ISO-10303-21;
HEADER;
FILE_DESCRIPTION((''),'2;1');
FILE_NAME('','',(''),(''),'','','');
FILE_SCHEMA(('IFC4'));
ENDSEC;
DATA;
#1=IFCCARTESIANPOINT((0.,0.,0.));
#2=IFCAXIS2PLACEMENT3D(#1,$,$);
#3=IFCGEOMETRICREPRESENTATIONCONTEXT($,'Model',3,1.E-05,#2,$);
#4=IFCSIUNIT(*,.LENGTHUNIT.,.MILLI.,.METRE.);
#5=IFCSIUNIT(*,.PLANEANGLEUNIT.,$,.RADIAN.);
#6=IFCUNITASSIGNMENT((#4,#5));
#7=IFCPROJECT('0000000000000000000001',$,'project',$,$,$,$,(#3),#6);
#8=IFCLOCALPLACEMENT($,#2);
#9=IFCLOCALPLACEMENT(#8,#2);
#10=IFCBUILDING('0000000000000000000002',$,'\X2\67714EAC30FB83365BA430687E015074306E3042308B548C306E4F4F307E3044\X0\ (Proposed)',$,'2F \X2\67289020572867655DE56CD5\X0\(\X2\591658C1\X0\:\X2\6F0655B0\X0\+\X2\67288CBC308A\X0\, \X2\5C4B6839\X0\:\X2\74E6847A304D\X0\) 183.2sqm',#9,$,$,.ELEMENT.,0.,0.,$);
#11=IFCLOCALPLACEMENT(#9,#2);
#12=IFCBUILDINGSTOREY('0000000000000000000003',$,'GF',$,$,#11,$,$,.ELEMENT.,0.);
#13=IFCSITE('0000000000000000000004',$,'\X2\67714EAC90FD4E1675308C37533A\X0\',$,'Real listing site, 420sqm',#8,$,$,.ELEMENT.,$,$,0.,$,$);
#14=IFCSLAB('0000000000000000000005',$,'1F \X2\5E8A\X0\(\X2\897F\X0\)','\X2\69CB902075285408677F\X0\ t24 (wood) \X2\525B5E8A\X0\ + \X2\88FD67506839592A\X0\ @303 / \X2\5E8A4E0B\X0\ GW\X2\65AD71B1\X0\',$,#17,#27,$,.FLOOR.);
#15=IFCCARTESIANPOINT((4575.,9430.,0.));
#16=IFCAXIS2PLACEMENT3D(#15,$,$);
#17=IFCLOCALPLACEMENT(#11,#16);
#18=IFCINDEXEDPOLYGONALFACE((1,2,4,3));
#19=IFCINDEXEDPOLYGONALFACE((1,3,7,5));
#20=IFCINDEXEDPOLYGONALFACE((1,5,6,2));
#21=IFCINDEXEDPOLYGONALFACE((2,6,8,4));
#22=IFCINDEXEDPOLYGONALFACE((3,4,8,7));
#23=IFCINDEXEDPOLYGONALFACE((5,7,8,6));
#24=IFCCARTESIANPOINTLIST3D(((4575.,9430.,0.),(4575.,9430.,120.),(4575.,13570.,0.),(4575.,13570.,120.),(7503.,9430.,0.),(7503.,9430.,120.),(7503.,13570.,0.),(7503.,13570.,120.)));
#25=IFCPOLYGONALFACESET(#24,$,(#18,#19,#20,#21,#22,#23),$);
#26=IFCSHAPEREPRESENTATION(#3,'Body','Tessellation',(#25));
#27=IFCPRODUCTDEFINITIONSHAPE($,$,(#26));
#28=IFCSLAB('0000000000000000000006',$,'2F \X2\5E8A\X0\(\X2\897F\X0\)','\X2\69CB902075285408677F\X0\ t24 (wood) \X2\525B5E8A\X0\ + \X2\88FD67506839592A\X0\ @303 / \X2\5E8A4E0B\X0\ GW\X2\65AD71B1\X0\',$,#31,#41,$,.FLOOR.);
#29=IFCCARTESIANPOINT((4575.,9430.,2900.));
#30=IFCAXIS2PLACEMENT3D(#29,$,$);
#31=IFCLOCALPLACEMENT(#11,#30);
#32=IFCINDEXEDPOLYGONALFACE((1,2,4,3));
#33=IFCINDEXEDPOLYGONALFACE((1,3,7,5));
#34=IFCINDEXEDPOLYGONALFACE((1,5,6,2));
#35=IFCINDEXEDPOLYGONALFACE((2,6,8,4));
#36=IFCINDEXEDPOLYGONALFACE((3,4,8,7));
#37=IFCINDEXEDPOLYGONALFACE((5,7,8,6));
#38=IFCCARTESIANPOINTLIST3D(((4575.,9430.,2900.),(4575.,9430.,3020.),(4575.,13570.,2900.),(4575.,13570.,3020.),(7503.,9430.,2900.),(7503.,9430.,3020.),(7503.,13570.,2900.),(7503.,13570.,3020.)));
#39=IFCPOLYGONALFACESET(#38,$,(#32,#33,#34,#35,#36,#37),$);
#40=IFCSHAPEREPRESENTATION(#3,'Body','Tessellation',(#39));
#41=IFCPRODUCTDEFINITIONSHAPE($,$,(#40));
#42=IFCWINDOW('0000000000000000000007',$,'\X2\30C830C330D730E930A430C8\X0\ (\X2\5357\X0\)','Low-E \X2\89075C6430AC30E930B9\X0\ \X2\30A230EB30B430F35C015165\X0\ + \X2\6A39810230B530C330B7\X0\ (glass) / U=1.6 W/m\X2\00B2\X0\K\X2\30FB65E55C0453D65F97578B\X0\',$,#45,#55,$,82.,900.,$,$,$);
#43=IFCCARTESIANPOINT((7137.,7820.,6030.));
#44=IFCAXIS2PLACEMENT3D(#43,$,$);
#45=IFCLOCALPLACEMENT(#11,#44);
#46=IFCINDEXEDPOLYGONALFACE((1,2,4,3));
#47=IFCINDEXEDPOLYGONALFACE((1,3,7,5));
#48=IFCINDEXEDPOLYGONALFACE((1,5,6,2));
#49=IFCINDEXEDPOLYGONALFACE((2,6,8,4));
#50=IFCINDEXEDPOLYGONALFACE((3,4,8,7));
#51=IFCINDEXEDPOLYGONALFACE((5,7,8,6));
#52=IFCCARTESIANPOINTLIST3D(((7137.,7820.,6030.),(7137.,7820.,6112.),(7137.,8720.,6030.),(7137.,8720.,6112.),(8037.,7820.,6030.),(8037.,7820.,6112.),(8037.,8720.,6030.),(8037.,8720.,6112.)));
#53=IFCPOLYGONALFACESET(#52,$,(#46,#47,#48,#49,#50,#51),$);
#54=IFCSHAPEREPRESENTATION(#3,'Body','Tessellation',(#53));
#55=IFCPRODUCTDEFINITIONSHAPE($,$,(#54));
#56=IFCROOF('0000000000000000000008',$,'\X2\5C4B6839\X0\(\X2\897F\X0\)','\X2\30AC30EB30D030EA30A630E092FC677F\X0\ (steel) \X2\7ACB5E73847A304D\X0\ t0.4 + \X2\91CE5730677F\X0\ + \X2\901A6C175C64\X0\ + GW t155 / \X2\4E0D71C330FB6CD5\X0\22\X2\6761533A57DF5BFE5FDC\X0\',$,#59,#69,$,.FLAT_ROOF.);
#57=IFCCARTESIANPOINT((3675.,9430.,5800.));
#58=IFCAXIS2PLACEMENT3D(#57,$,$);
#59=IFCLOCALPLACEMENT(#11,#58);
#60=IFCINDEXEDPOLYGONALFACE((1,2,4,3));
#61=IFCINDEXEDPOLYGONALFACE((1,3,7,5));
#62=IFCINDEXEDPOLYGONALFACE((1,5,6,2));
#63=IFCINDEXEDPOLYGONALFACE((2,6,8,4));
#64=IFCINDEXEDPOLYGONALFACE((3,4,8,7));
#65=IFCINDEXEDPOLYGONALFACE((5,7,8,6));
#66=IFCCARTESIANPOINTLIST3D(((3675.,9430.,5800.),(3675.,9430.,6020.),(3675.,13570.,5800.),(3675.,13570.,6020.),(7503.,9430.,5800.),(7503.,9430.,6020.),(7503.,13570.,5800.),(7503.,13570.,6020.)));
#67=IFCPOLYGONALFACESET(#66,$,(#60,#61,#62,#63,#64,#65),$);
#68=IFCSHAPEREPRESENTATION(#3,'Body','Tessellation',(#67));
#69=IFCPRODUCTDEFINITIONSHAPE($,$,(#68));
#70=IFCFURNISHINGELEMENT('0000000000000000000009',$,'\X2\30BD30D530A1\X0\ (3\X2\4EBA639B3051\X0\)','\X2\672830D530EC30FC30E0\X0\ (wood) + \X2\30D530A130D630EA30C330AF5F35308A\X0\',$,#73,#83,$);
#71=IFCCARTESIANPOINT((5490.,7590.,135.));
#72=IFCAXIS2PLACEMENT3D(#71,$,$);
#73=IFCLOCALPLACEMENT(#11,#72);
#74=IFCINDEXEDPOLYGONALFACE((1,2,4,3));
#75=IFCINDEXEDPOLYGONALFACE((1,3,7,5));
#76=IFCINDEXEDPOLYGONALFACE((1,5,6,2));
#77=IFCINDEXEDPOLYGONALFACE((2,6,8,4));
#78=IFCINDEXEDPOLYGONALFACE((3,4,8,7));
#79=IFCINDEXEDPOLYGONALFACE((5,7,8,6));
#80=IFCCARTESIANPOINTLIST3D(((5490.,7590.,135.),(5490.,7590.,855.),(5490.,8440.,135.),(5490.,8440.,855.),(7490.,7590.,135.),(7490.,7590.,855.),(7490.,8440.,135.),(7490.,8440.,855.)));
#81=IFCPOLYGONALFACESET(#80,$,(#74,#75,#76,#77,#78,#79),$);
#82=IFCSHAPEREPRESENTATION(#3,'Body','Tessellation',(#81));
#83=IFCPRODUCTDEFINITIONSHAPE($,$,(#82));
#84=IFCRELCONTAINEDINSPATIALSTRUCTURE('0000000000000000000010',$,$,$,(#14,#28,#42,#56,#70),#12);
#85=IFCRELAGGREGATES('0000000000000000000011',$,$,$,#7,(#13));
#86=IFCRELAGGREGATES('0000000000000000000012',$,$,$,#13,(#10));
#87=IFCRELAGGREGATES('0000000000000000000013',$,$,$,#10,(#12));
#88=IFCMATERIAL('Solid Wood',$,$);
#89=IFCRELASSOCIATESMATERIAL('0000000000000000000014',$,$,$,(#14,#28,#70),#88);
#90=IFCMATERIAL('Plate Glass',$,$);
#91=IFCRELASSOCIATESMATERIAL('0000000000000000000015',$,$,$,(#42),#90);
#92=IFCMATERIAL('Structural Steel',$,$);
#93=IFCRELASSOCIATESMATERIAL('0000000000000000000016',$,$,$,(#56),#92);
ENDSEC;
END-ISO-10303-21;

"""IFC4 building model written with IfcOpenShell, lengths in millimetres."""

from ifc_helpers import new_model, si_unit, frame, frame_2d, origin, place, context, project, spatial, rectangle, extrude, material, element, save


model = new_model("IFC4")

# Units and contexts
model_context = context("Model", 3, precision=1e-05, world=origin())
ifc_project = project(units=[si_unit("LENGTHUNIT", "METRE", prefix="MILLI"), si_unit("PLANEANGLEUNIT", "RADIAN")], contexts=[model_context])

# Site, building, storey
site_placement = place(None, origin())
site = spatial("IfcSite", under=ifc_project, at=site_placement, Name="東京都世田谷区", ObjectType="Real listing site, 420sqm", CompositionType="ELEMENT", RefElevation=0.0)
building_placement = place(site_placement, origin())
building = spatial("IfcBuilding", under=site, at=building_placement, Name="東京・茶室と縁側のある和の住まい (Proposed)", ObjectType="2F 木造在来工法(外壁:漆喰+木貼り, 屋根:瓦葺き) 183.2sqm", CompositionType="ELEMENT", ElevationOfRefHeight=0.0, ElevationOfTerrain=0.0)
storey_placement = place(building_placement, origin())
storey = spatial("IfcBuildingStorey", under=building, at=storey_placement, Name="GF", CompositionType="ELEMENT", Elevation=0.0)

# Shared definitions
ifc_material_1 = material(Name="Solid Wood")

# Slabs
slab_1_placement = place(storey_placement, frame((4575.0, 9430.0, 0.0)))
element("IfcSlab", 1, at=slab_1_placement, inside=storey, material=ifc_material_1, Name="1F 床(西)", Description="構造用合板 t24 (wood) 剛床 + 製材根太 @303 / 床下 GW断熱", PredefinedType="FLOOR", context=model_context, shape_type="SweptSolid", body=[
    extrude(rectangle(XDim=2928.0, YDim=4140.0, at=frame_2d((1464.0, 2070.0))), frame((4575.0, 9430.0, 0.0)), (0.0, 0.0, 1.0), 120.0),
])
slab_2_placement = place(storey_placement, frame((4575.0, 9430.0, 2900.0)))
element("IfcSlab", 2, at=slab_2_placement, inside=storey, material=ifc_material_1, Name="2F 床(西)", Description="構造用合板 t24 (wood) 剛床 + 製材根太 @303 / 床下 GW断熱", PredefinedType="FLOOR", context=model_context, shape_type="SweptSolid", body=[
    extrude(rectangle(XDim=2928.0, YDim=4140.0, at=frame_2d((1464.0, 2070.0))), frame((4575.0, 9430.0, 2900.0)), (0.0, 0.0, 1.0), 120.0),
])

# Window
ifc_material_2 = material(Name="Plate Glass")
window_placement = place(storey_placement, frame((7137.0, 7820.0, 6030.0)))
element("IfcWindow", 3, at=window_placement, inside=storey, material=ifc_material_2, Name="トップライト (南)", Description="Low-E 複層ガラス アルゴン封入 + 樹脂サッシ (glass) / U=1.6 W/m²K・日射取得型", OverallHeight=82.0, OverallWidth=900.0, context=model_context, shape_type="SweptSolid", body=[
    extrude(rectangle(XDim=900.0, YDim=900.0, at=frame_2d((450.0, 450.0))), frame((7137.0, 7820.0, 6030.0)), (0.0, 0.0, 1.0), 82.0),
])

# Roof
ifc_material_3 = material(Name="Structural Steel")
for number, where, name in (
    (4, (3675.0, 9430.0, 5800.0), "屋根(西)"),
):
    element("IfcRoof", number, at=place(storey_placement, frame(where)), inside=storey, material=ifc_material_3, Name=name, Description="ガルバリウム鋼板 (steel) 立平葺き t0.4 + 野地板 + 通気層 + GW t155 / 不燃・法22条区域対応", PredefinedType="FLAT_ROOF", context=model_context, shape_type="SweptSolid", body=[
        extrude(rectangle(XDim=3828.0, YDim=4140.0, at=frame_2d((1914.0, 2070.0))), frame((3675.0, 9430.0, 5800.0)), (0.0, 0.0, 1.0), 220.0),
    ])

# Furnishing element
furnishing_placement = place(storey_placement, frame((5490.0, 7590.0, 135.0)))
element("IfcFurnishingElement", 5, at=furnishing_placement, inside=storey, material=ifc_material_1, Name="ソファ (3人掛け)", Description="木フレーム (wood) + ファブリック張り", context=model_context, shape_type="SweptSolid", body=[
    extrude(rectangle(XDim=2000.0, YDim=850.0, at=frame_2d((1000.0, 425.0))), frame((5490.0, 7590.0, 135.0)), (0.0, 0.0, 1.0), 720.0),
])

save(model, "model.ifc")
